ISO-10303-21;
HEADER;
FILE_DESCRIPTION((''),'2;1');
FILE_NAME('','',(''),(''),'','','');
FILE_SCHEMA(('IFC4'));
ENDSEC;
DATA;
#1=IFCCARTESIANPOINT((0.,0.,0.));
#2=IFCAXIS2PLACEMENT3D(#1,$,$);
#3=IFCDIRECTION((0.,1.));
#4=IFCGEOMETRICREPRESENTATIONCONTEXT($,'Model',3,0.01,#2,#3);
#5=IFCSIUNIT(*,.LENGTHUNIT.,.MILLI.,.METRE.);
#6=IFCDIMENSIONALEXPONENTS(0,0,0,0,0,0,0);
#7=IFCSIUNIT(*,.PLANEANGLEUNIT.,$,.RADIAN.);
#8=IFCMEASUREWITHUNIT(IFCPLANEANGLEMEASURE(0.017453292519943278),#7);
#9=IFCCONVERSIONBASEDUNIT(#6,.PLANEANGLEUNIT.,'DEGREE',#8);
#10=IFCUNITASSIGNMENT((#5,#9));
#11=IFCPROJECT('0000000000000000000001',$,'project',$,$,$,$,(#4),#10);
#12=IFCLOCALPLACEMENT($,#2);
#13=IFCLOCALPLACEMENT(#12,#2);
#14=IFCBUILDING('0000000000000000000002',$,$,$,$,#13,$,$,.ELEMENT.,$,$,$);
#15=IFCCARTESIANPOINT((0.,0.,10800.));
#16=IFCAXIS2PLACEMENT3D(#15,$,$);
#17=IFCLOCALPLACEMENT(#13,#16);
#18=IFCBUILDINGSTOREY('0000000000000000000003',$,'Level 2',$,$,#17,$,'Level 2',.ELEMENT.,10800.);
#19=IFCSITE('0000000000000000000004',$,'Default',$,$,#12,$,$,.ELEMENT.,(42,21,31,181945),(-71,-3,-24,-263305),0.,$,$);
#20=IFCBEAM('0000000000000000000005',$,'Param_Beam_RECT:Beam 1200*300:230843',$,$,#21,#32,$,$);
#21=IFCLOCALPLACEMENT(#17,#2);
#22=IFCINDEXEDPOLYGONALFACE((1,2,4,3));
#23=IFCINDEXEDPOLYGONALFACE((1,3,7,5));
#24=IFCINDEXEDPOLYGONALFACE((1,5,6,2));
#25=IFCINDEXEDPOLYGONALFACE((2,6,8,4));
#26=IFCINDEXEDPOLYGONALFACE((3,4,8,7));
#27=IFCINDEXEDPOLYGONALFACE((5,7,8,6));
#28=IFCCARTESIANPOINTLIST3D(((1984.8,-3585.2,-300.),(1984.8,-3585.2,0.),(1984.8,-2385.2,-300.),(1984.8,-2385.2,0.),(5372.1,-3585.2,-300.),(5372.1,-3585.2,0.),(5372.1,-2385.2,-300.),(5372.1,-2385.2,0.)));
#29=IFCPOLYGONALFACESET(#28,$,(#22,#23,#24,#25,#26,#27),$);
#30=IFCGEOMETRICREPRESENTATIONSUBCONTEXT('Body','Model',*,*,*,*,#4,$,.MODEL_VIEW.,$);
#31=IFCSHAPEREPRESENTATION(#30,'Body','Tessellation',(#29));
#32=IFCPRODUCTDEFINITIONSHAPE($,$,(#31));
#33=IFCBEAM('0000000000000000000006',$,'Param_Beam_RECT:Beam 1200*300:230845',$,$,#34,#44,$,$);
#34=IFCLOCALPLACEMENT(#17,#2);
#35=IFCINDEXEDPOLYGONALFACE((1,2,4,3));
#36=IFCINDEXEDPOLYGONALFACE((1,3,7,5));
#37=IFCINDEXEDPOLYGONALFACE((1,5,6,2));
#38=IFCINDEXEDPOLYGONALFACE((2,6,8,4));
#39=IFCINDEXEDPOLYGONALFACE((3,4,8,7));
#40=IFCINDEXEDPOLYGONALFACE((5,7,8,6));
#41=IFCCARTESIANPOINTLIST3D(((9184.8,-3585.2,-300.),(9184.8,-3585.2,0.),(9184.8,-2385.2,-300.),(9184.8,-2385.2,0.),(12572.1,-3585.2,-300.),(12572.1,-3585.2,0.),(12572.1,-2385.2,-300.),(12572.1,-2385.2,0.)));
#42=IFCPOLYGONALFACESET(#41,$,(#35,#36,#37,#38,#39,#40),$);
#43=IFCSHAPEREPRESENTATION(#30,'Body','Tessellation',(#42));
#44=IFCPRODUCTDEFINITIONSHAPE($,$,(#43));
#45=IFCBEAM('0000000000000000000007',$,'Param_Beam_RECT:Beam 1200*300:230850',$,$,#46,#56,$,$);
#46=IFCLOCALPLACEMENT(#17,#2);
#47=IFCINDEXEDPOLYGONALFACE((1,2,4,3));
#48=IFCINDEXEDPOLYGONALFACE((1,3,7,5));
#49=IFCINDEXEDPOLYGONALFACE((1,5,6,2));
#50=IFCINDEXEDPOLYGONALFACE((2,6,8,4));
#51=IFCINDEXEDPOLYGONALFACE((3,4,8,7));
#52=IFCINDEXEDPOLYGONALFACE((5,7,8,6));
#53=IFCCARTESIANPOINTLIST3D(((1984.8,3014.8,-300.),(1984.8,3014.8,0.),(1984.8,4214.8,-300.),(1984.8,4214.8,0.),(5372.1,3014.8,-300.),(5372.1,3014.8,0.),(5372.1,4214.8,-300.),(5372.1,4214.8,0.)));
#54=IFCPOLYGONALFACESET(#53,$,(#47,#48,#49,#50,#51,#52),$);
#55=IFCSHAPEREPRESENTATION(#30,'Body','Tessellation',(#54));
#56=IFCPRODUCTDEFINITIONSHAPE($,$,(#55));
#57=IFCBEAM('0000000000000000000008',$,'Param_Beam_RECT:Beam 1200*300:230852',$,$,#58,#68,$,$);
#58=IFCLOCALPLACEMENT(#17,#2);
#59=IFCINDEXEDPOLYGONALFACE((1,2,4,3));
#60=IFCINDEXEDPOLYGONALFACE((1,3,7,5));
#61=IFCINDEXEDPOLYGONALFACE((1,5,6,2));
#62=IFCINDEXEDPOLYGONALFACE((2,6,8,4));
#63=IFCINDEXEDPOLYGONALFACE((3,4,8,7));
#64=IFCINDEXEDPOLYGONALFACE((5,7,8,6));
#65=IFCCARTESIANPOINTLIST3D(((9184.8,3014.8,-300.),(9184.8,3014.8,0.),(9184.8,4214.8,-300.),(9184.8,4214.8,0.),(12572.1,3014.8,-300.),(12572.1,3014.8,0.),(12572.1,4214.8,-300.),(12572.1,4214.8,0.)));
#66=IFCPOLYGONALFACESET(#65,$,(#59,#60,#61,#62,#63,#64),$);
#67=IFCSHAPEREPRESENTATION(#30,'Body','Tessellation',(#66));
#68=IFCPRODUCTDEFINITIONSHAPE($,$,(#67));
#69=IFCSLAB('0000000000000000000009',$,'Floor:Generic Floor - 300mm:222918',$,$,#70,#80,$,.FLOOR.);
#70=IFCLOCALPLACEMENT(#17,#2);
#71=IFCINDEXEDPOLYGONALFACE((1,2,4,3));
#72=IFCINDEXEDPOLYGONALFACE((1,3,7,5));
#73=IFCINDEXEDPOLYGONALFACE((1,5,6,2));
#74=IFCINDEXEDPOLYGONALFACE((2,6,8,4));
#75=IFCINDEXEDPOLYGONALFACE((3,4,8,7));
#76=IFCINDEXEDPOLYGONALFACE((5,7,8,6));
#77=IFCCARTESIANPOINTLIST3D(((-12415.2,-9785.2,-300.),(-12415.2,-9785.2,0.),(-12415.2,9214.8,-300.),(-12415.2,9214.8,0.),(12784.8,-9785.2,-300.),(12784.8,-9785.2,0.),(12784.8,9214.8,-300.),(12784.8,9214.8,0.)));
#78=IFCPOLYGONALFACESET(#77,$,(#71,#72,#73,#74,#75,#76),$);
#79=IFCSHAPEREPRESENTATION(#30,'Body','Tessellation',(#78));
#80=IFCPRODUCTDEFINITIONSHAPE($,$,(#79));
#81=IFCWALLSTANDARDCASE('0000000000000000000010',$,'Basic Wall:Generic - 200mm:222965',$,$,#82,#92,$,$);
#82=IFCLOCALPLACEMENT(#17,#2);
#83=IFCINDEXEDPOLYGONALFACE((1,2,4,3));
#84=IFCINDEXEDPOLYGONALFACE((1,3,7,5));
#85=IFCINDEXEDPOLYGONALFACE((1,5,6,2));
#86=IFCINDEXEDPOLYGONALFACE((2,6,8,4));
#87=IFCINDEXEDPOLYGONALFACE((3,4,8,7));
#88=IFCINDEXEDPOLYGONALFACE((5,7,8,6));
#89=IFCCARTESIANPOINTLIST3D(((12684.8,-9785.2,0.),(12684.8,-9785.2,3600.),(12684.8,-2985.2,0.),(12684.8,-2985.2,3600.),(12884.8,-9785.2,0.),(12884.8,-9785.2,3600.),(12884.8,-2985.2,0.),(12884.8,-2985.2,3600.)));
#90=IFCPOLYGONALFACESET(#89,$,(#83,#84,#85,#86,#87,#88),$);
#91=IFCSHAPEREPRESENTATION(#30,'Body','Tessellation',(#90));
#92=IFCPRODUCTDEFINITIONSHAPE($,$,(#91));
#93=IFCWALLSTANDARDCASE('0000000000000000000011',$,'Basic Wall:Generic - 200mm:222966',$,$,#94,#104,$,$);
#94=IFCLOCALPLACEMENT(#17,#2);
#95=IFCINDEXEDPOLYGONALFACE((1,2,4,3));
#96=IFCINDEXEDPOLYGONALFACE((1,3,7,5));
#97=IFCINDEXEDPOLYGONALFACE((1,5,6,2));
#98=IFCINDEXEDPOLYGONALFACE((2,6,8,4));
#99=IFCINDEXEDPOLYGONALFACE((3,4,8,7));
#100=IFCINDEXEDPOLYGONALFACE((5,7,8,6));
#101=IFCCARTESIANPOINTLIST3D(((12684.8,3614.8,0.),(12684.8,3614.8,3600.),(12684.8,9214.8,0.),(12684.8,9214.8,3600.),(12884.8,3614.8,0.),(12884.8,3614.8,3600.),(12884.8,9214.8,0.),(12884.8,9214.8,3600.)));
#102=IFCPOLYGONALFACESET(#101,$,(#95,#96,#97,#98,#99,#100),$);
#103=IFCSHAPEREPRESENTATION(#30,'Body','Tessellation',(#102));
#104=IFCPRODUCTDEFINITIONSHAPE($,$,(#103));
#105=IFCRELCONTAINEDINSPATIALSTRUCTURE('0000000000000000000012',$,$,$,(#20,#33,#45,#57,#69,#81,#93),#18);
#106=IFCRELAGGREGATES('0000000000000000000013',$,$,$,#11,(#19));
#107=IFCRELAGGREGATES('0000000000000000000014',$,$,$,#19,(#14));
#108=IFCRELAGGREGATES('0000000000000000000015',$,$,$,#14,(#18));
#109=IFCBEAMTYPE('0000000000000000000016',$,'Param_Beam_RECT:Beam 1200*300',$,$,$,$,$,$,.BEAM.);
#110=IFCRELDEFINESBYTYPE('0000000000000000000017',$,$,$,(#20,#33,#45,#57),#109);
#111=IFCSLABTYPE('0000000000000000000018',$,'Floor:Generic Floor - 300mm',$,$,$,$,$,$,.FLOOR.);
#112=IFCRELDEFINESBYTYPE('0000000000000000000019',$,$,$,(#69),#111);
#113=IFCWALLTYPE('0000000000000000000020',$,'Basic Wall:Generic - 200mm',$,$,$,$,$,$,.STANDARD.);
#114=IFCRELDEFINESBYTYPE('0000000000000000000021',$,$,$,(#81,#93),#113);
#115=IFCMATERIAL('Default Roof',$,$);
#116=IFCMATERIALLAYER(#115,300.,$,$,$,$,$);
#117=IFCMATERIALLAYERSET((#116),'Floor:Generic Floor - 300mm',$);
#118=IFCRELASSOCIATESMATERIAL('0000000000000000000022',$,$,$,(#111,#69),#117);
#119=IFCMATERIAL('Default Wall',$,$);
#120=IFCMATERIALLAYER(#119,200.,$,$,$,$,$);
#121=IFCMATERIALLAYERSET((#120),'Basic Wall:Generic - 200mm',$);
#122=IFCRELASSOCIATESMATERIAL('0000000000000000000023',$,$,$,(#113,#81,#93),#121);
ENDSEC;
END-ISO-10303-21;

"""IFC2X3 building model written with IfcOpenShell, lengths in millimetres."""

from ifc_helpers import new_model, entity, si_unit, converted_unit, direction, frame, frame_2d, origin, origin_2d_with_axis, place, context, subcontext, project, spatial, rectangle, extrude, material, layer, layer_set, layer_usage, type_object, element, save


model = new_model("IFC2X3")

# Units and contexts
model_context = context("Model", 3, precision=0.01, world=origin(), true_north=direction((0.0, 1.0)))
body_context = subcontext(model_context, "Body", "Model", "MODEL_VIEW")
ifc_project = project(units=[si_unit("LENGTHUNIT", "METRE", prefix="MILLI"), converted_unit("PLANEANGLEUNIT", "DEGREE", entity("IfcPlaneAngleMeasure", 0.017453292519943278), si_unit("PLANEANGLEUNIT", "RADIAN"), dimensions=[0, 0, 0, 0, 0, 0, 0])], contexts=[model_context])

# Site, building, storey
site_placement = place(None, origin())
site = spatial("IfcSite", under=ifc_project, at=site_placement, Name="Default", CompositionType="ELEMENT", RefLatitude=(42, 21, 31, 181945), RefLongitude=(-71, -3, -24, -263305), RefElevation=0.0)
building_placement = place(site_placement, origin())
building = spatial("IfcBuilding", under=site, at=building_placement, CompositionType="ELEMENT")
storey_placement = place(building_placement, frame((0.0, 0.0, 10800.0)))
storey = spatial("IfcBuildingStorey", under=building, at=storey_placement, Name="Level 2", LongName="Level 2", CompositionType="ELEMENT", Elevation=10800.0)

# Beams
beam_type_1 = type_object("IfcBeamType", Name="Param_Beam_RECT:Beam 1200*300", PredefinedType="BEAM")
beam_1_placement = place(storey_placement, frame((1984.8, -2985.2, 0.0)))
element("IfcBeam", 1, at=beam_1_placement, inside=storey, type_object=beam_type_1, Name="Param_Beam_RECT:Beam 1200*300:230843", context=body_context, shape_type="SweptSolid", body=[
    extrude(rectangle(XDim=300.0, YDim=1200.0, at=frame_2d((0.0, 0.0), x_axis=(1.0, 0.0))), frame((0.0, 0.0, -150.0), z_axis=(1.0, 0.0, 0.0), x_axis=(0.0, 0.0, -1.0)), (0.0, 0.0, 1.0), 3387.3),
])
beam_2_placement = place(storey_placement, frame((9184.8, -2985.2, 0.0)))
element("IfcBeam", 2, at=beam_2_placement, inside=storey, type_object=beam_type_1, Name="Param_Beam_RECT:Beam 1200*300:230845", context=body_context, shape_type="SweptSolid", body=[
    extrude(rectangle(XDim=300.0, YDim=1200.0, at=frame_2d((0.0, 0.0), x_axis=(1.0, 0.0))), frame((0.0, 0.0, -150.0), z_axis=(1.0, 0.0, 0.0), x_axis=(0.0, 0.0, -1.0)), (0.0, 0.0, 1.0), 3387.3),
])
beam_3_placement = place(storey_placement, frame((1984.8, 3614.8, 0.0)))
element("IfcBeam", 3, at=beam_3_placement, inside=storey, type_object=beam_type_1, Name="Param_Beam_RECT:Beam 1200*300:230850", context=body_context, shape_type="SweptSolid", body=[
    extrude(rectangle(XDim=300.0, YDim=1200.0, at=frame_2d((0.0, 0.0), x_axis=(1.0, 0.0))), frame((0.0, 0.0, -150.0), z_axis=(1.0, 0.0, 0.0), x_axis=(0.0, 0.0, -1.0)), (0.0, 0.0, 1.0), 3387.3),
])
beam_4_placement = place(storey_placement, frame((9184.8, 3614.8, 0.0)))
element("IfcBeam", 4, at=beam_4_placement, inside=storey, type_object=beam_type_1, Name="Param_Beam_RECT:Beam 1200*300:230852", context=body_context, shape_type="SweptSolid", body=[
    extrude(rectangle(XDim=300.0, YDim=1200.0, at=frame_2d((0.0, 0.0), x_axis=(1.0, 0.0))), frame((0.0, 0.0, -150.0), z_axis=(1.0, 0.0, 0.0), x_axis=(0.0, 0.0, -1.0)), (0.0, 0.0, 1.0), 3387.3),
])

# Slab
ifc_material_1 = material(Name="Default Roof")
ifc_layer_1 = layer(ifc_material_1, 300.0)
ifc_layer_set_1 = layer_set([ifc_layer_1], Name="Floor:Generic Floor - 300mm")
ifc_layer_usage_1 = layer_usage(ifc_layer_set_1, "AXIS3", "POSITIVE", 0.0)
slab_type = type_object("IfcSlabType", Name="Floor:Generic Floor - 300mm", PredefinedType="FLOOR", material=ifc_layer_set_1)
slab_placement = place(storey_placement, origin())
element("IfcSlab", 5, at=slab_placement, inside=storey, type_object=slab_type, material=ifc_layer_usage_1, Name="Floor:Generic Floor - 300mm:222918", PredefinedType="FLOOR", context=body_context, shape_type="SweptSolid", body=[
    extrude(rectangle(XDim=19000.0, YDim=25200.0, at=origin_2d_with_axis()), frame((184.8, -285.2, 0.0), z_axis=(0.0, 0.0, -1.0), x_axis=(0.0, 1.0, 0.0)), (0.0, 0.0, 1.0), 300.0),
])

# Walls
ifc_material_2 = material(Name="Default Wall")
ifc_layer_2 = layer(ifc_material_2, 200.0)
ifc_layer_set_2 = layer_set([ifc_layer_2], Name="Basic Wall:Generic - 200mm")
ifc_layer_usage_2 = layer_usage(ifc_layer_set_2, "AXIS2", "NEGATIVE", 100.0)
wall_type = type_object("IfcWallType", Name="Basic Wall:Generic - 200mm", PredefinedType="STANDARD", material=ifc_layer_set_2)
wall_1_placement = place(storey_placement, frame((12784.8, -9785.2, 0.0), z_axis=(0.0, 0.0, 1.0), x_axis=(0.0, 1.0, 0.0)))
element("IfcWallStandardCase", 6, at=wall_1_placement, inside=storey, type_object=wall_type, material=ifc_layer_usage_2, Name="Basic Wall:Generic - 200mm:222965", context=body_context, shape_type="SweptSolid", body=[
    extrude(rectangle(XDim=6800.0, YDim=200.0, at=frame_2d((3400.0, 0.0), x_axis=(-1.0, 0.0))), origin(), (0.0, 0.0, 1.0), 3600.0),
])
ifc_layer_usage_3 = layer_usage(ifc_layer_set_2, "AXIS2", "NEGATIVE", 100.0)
wall_2_placement = place(storey_placement, frame((12784.8, 3614.8, 0.0), z_axis=(0.0, 0.0, 1.0), x_axis=(0.0, 1.0, 0.0)))
element("IfcWallStandardCase", 7, at=wall_2_placement, inside=storey, type_object=wall_type, material=ifc_layer_usage_3, Name="Basic Wall:Generic - 200mm:222966", context=body_context, shape_type="SweptSolid", body=[
    extrude(rectangle(XDim=5600.0, YDim=200.0, at=frame_2d((2800.0, 0.0), x_axis=(-1.0, 0.0))), origin(), (0.0, 0.0, 1.0), 3600.0),
])

save(model, "model.ifc")
